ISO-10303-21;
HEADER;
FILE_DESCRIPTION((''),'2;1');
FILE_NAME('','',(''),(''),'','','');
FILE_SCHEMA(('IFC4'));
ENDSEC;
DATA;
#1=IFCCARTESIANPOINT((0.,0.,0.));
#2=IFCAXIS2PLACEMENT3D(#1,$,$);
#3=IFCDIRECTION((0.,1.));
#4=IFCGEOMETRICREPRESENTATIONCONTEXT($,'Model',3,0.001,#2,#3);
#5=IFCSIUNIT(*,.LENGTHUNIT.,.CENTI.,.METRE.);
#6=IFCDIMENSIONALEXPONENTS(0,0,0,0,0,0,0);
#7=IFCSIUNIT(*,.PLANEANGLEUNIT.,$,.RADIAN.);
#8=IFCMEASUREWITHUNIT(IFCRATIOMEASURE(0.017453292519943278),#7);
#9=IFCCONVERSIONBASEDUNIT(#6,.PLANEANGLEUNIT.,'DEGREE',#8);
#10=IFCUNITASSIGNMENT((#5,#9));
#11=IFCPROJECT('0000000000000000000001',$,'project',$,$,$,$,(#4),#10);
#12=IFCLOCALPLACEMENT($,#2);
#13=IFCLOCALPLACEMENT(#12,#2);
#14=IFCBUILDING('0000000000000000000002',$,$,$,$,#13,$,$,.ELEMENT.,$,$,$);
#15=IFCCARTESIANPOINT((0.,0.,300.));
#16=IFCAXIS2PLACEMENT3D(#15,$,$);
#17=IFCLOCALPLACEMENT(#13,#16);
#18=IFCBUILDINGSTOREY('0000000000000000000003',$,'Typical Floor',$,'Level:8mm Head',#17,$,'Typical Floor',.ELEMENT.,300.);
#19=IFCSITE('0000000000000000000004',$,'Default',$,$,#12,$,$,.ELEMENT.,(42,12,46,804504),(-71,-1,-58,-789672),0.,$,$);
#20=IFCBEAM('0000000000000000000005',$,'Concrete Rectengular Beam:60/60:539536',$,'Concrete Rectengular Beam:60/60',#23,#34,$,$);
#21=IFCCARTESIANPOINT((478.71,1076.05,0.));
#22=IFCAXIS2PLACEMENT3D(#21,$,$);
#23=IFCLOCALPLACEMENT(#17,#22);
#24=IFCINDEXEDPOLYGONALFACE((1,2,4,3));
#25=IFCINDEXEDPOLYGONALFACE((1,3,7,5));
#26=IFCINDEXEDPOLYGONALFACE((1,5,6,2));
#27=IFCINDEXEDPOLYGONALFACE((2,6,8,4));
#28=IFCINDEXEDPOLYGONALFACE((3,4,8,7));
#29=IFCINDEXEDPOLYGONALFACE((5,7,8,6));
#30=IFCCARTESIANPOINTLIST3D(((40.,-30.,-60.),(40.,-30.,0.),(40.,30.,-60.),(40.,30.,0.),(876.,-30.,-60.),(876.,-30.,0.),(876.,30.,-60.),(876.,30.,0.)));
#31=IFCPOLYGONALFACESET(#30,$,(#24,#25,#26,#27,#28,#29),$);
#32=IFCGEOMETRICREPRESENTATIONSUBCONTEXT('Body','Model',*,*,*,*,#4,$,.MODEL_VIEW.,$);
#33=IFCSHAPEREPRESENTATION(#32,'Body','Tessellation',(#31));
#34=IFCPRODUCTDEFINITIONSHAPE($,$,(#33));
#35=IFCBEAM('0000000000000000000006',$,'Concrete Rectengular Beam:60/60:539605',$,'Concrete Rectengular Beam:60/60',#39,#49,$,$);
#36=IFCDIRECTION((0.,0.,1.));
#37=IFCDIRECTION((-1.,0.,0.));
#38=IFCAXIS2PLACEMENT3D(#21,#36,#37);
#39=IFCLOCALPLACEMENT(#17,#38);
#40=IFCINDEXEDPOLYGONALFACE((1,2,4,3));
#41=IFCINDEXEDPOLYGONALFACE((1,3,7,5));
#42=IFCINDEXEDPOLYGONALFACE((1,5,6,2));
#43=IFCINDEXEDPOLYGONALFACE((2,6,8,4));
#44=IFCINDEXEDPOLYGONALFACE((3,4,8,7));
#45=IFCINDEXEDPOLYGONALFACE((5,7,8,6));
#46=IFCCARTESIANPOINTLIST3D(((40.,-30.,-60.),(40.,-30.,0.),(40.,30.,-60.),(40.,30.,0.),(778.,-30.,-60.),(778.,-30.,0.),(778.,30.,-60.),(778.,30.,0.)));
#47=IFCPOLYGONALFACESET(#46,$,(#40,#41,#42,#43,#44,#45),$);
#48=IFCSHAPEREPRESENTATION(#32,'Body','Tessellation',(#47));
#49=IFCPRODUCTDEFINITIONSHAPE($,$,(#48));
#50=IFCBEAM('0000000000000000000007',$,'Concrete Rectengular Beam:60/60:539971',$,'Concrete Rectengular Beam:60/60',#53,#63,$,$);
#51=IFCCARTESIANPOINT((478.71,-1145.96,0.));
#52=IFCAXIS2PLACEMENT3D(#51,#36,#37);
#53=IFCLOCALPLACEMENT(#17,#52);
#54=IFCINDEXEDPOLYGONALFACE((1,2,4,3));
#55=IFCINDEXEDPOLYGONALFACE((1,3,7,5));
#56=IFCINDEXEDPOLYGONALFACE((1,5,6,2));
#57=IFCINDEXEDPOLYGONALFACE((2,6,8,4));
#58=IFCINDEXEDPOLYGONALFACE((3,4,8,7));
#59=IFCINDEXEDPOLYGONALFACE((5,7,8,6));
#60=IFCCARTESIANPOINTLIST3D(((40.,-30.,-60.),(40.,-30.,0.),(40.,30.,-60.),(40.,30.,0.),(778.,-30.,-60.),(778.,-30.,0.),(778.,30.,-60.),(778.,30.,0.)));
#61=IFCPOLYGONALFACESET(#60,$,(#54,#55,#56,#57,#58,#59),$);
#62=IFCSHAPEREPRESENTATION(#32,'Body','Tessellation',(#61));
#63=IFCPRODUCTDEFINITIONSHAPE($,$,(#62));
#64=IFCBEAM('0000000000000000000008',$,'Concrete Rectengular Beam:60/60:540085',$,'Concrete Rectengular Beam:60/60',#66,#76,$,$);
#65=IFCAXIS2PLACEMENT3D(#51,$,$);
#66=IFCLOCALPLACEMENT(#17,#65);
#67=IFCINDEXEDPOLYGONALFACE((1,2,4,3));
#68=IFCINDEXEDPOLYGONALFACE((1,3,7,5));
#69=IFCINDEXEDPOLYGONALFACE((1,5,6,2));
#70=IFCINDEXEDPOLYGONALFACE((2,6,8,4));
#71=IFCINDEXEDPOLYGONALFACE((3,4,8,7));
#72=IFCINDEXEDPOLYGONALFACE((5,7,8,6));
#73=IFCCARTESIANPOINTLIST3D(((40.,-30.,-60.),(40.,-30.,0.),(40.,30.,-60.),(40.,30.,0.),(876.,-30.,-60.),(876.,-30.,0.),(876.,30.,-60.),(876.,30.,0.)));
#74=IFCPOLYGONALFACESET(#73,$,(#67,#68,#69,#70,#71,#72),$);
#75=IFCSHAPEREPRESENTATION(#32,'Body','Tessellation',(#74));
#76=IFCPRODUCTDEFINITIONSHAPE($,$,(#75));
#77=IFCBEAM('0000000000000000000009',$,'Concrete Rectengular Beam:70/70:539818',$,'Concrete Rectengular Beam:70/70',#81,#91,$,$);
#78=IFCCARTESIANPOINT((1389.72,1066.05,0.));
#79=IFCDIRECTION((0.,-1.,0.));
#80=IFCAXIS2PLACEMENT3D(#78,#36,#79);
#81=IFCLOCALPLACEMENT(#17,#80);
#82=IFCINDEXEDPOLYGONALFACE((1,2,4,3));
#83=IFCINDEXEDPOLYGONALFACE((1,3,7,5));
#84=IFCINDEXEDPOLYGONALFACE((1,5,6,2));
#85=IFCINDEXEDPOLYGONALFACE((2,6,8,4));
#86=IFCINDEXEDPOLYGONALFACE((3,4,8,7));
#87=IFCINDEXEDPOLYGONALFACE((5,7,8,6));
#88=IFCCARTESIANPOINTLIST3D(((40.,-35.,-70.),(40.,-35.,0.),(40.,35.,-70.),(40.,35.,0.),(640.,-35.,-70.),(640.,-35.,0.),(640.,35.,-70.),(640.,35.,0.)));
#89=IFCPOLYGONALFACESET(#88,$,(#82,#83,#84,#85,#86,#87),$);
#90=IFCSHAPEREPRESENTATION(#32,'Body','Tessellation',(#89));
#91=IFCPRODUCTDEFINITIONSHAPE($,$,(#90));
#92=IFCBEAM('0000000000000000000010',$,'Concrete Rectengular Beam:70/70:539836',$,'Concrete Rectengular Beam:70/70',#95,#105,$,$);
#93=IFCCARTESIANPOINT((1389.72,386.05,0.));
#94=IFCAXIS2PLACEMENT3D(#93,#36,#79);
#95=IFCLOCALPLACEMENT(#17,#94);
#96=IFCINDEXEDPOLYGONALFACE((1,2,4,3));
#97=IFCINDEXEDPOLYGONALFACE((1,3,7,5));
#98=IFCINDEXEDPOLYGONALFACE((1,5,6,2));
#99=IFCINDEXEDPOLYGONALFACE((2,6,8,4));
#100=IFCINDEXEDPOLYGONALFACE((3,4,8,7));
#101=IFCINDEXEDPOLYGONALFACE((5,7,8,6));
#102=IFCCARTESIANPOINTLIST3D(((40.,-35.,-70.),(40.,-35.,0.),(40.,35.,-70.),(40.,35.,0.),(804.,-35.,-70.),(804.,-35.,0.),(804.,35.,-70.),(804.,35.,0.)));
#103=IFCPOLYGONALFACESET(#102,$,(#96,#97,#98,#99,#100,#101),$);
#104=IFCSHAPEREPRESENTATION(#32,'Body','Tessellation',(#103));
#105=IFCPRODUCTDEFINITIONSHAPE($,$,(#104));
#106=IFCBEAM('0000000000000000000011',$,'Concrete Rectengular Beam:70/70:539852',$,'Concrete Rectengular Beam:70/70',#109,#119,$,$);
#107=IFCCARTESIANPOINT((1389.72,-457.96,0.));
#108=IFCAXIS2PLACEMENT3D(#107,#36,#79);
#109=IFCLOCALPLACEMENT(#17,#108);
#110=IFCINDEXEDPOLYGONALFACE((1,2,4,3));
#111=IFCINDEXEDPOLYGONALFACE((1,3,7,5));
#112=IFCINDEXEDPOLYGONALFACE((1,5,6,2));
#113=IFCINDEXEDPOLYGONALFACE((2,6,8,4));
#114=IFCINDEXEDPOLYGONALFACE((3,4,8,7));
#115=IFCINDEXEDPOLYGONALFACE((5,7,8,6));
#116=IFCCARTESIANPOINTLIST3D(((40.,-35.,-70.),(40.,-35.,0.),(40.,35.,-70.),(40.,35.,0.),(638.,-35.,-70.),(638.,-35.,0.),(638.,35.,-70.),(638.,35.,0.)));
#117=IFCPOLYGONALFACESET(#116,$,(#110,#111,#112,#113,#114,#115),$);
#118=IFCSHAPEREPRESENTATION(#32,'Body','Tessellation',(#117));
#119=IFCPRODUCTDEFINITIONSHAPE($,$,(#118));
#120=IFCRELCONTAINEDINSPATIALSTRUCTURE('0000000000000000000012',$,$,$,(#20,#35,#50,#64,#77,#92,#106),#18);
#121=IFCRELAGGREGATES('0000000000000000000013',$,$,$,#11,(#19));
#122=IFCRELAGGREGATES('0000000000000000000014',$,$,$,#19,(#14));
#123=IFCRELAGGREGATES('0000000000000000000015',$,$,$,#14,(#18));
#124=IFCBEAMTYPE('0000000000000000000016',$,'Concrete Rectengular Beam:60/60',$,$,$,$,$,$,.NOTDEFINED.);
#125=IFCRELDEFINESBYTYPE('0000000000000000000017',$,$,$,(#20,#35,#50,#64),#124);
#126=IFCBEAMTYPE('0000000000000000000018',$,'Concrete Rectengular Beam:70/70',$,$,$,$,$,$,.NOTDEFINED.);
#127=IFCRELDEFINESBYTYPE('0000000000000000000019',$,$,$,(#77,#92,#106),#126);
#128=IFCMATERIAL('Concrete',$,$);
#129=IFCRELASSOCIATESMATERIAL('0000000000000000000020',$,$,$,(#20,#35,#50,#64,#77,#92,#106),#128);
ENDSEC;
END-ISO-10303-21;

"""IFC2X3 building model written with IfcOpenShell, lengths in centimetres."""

from ifc_helpers import new_model, entity, si_unit, converted_unit, direction, frame, frame_2d, origin, origin_2d_with_axis, place, context, subcontext, project, spatial, rectangle, extrude, material, type_object, element, save


model = new_model("IFC2X3")

# Units and contexts
model_context = context("Model", 3, precision=0.001, world=origin(), true_north=direction((0.0, 1.0)))
body_context = subcontext(model_context, "Body", "Model", "MODEL_VIEW")
ifc_project = project(units=[si_unit("LENGTHUNIT", "METRE", prefix="CENTI"), converted_unit("PLANEANGLEUNIT", "DEGREE", entity("IfcRatioMeasure", 0.017453292519943278), si_unit("PLANEANGLEUNIT", "RADIAN"), dimensions=[0, 0, 0, 0, 0, 0, 0])], contexts=[model_context])

# Site, building, storey
site_placement = place(None, origin())
site = spatial("IfcSite", under=ifc_project, at=site_placement, Name="Default", CompositionType="ELEMENT", RefLatitude=(42, 12, 46, 804504), RefLongitude=(-71, -1, -58, -789672), RefElevation=0.0)
building_placement = place(site_placement, origin())
building = spatial("IfcBuilding", under=site, at=building_placement, CompositionType="ELEMENT")
storey_placement = place(building_placement, frame((0.0, 0.0, 300.0)))
storey = spatial("IfcBuildingStorey", under=building, at=storey_placement, Name="Typical Floor", ObjectType="Level:8mm Head", LongName="Typical Floor", CompositionType="ELEMENT", Elevation=300.0)

# Beams
ifc_material = material(Name="Concrete")
beam_type_1 = type_object("IfcBeamType", Name="Concrete Rectengular Beam:60/60", PredefinedType="NOTDEFINED")
beam_1_placement = place(storey_placement, frame((478.71, 1076.05, 0.0)))
element("IfcBeam", 1, at=beam_1_placement, inside=storey, type_object=beam_type_1, material=ifc_material, Name="Concrete Rectengular Beam:60/60:539536", ObjectType="Concrete Rectengular Beam:60/60", context=body_context, shape_type="SweptSolid", body=[
    extrude(rectangle(XDim=60.0, YDim=60.0, at=frame_2d((0.0, 0.0), x_axis=(1.0, 0.0))), frame((40.0, 0.0, -30.0), z_axis=(1.0, 0.0, 0.0), x_axis=(0.0, 0.0, -1.0)), (0.0, 0.0, 1.0), 836.0),
])
beam_2_placement = place(storey_placement, frame((478.71, 1076.05, 0.0), z_axis=(0.0, 0.0, 1.0), x_axis=(-1.0, 0.0, 0.0)))
element("IfcBeam", 2, at=beam_2_placement, inside=storey, type_object=beam_type_1, material=ifc_material, Name="Concrete Rectengular Beam:60/60:539605", ObjectType="Concrete Rectengular Beam:60/60", context=body_context, shape_type="SweptSolid", body=[
    extrude(rectangle(XDim=60.0, YDim=60.0, at=frame_2d((0.0, 0.0), x_axis=(1.0, 0.0))), frame((40.0, 0.0, -30.0), z_axis=(1.0, 0.0, 0.0), x_axis=(0.0, 0.0, -1.0)), (0.0, 0.0, 1.0), 738.0),
])
beam_3_placement = place(storey_placement, frame((478.71, -1145.96, 0.0), z_axis=(0.0, 0.0, 1.0), x_axis=(-1.0, 0.0, 0.0)))
element("IfcBeam", 3, at=beam_3_placement, inside=storey, type_object=beam_type_1, material=ifc_material, Name="Concrete Rectengular Beam:60/60:539971", ObjectType="Concrete Rectengular Beam:60/60", context=body_context, shape_type="SweptSolid", body=[
    extrude(rectangle(XDim=60.0, YDim=60.0, at=frame_2d((0.0, 0.0), x_axis=(1.0, 0.0))), frame((40.0, 0.0, -30.0), z_axis=(1.0, 0.0, 0.0), x_axis=(0.0, 0.0, -1.0)), (0.0, 0.0, 1.0), 738.0),
])
beam_4_placement = place(storey_placement, frame((478.71, -1145.96, 0.0)))
element("IfcBeam", 4, at=beam_4_placement, inside=storey, type_object=beam_type_1, material=ifc_material, Name="Concrete Rectengular Beam:60/60:540085", ObjectType="Concrete Rectengular Beam:60/60", context=body_context, shape_type="SweptSolid", body=[
    extrude(rectangle(XDim=60.0, YDim=60.0, at=frame_2d((0.0, 0.0), x_axis=(1.0, 0.0))), frame((40.0, 0.0, -30.0), z_axis=(1.0, 0.0, 0.0), x_axis=(0.0, 0.0, -1.0)), (0.0, 0.0, 1.0), 836.0),
])
beam_type_2 = type_object("IfcBeamType", Name="Concrete Rectengular Beam:70/70", PredefinedType="NOTDEFINED")
beam_5_placement = place(storey_placement, frame((1389.72, 1066.05, 0.0), z_axis=(0.0, 0.0, 1.0), x_axis=(0.0, -1.0, 0.0)))
element("IfcBeam", 5, at=beam_5_placement, inside=storey, type_object=beam_type_2, material=ifc_material, Name="Concrete Rectengular Beam:70/70:539818", ObjectType="Concrete Rectengular Beam:70/70", context=body_context, shape_type="SweptSolid", body=[
    extrude(rectangle(XDim=70.0, YDim=70.0, at=origin_2d_with_axis()), frame((40.0, 0.0, -35.0), z_axis=(1.0, 0.0, 0.0), x_axis=(0.0, 0.0, -1.0)), (0.0, 0.0, 1.0), 600.0),
])
beam_6_placement = place(storey_placement, frame((1389.72, 386.05, 0.0), z_axis=(0.0, 0.0, 1.0), x_axis=(0.0, -1.0, 0.0)))
element("IfcBeam", 6, at=beam_6_placement, inside=storey, type_object=beam_type_2, material=ifc_material, Name="Concrete Rectengular Beam:70/70:539836", ObjectType="Concrete Rectengular Beam:70/70", context=body_context, shape_type="SweptSolid", body=[
    extrude(rectangle(XDim=70.0, YDim=70.0, at=frame_2d((0.0, 0.0), x_axis=(1.0, 0.0))), frame((40.0, 0.0, -35.0), z_axis=(1.0, 0.0, 0.0), x_axis=(0.0, 0.0, -1.0)), (0.0, 0.0, 1.0), 764.0),
])
beam_7_placement = place(storey_placement, frame((1389.72, -457.96, 0.0), z_axis=(0.0, 0.0, 1.0), x_axis=(0.0, -1.0, 0.0)))
element("IfcBeam", 7, at=beam_7_placement, inside=storey, type_object=beam_type_2, material=ifc_material, Name="Concrete Rectengular Beam:70/70:539852", ObjectType="Concrete Rectengular Beam:70/70", context=body_context, shape_type="SweptSolid", body=[
    extrude(rectangle(XDim=70.0, YDim=70.0, at=frame_2d((0.0, 0.0), x_axis=(1.0, 0.0))), frame((40.0, 0.0, -35.0), z_axis=(1.0, 0.0, 0.0), x_axis=(0.0, 0.0, -1.0)), (0.0, 0.0, 1.0), 598.0),
])

save(model, "model.ifc")
